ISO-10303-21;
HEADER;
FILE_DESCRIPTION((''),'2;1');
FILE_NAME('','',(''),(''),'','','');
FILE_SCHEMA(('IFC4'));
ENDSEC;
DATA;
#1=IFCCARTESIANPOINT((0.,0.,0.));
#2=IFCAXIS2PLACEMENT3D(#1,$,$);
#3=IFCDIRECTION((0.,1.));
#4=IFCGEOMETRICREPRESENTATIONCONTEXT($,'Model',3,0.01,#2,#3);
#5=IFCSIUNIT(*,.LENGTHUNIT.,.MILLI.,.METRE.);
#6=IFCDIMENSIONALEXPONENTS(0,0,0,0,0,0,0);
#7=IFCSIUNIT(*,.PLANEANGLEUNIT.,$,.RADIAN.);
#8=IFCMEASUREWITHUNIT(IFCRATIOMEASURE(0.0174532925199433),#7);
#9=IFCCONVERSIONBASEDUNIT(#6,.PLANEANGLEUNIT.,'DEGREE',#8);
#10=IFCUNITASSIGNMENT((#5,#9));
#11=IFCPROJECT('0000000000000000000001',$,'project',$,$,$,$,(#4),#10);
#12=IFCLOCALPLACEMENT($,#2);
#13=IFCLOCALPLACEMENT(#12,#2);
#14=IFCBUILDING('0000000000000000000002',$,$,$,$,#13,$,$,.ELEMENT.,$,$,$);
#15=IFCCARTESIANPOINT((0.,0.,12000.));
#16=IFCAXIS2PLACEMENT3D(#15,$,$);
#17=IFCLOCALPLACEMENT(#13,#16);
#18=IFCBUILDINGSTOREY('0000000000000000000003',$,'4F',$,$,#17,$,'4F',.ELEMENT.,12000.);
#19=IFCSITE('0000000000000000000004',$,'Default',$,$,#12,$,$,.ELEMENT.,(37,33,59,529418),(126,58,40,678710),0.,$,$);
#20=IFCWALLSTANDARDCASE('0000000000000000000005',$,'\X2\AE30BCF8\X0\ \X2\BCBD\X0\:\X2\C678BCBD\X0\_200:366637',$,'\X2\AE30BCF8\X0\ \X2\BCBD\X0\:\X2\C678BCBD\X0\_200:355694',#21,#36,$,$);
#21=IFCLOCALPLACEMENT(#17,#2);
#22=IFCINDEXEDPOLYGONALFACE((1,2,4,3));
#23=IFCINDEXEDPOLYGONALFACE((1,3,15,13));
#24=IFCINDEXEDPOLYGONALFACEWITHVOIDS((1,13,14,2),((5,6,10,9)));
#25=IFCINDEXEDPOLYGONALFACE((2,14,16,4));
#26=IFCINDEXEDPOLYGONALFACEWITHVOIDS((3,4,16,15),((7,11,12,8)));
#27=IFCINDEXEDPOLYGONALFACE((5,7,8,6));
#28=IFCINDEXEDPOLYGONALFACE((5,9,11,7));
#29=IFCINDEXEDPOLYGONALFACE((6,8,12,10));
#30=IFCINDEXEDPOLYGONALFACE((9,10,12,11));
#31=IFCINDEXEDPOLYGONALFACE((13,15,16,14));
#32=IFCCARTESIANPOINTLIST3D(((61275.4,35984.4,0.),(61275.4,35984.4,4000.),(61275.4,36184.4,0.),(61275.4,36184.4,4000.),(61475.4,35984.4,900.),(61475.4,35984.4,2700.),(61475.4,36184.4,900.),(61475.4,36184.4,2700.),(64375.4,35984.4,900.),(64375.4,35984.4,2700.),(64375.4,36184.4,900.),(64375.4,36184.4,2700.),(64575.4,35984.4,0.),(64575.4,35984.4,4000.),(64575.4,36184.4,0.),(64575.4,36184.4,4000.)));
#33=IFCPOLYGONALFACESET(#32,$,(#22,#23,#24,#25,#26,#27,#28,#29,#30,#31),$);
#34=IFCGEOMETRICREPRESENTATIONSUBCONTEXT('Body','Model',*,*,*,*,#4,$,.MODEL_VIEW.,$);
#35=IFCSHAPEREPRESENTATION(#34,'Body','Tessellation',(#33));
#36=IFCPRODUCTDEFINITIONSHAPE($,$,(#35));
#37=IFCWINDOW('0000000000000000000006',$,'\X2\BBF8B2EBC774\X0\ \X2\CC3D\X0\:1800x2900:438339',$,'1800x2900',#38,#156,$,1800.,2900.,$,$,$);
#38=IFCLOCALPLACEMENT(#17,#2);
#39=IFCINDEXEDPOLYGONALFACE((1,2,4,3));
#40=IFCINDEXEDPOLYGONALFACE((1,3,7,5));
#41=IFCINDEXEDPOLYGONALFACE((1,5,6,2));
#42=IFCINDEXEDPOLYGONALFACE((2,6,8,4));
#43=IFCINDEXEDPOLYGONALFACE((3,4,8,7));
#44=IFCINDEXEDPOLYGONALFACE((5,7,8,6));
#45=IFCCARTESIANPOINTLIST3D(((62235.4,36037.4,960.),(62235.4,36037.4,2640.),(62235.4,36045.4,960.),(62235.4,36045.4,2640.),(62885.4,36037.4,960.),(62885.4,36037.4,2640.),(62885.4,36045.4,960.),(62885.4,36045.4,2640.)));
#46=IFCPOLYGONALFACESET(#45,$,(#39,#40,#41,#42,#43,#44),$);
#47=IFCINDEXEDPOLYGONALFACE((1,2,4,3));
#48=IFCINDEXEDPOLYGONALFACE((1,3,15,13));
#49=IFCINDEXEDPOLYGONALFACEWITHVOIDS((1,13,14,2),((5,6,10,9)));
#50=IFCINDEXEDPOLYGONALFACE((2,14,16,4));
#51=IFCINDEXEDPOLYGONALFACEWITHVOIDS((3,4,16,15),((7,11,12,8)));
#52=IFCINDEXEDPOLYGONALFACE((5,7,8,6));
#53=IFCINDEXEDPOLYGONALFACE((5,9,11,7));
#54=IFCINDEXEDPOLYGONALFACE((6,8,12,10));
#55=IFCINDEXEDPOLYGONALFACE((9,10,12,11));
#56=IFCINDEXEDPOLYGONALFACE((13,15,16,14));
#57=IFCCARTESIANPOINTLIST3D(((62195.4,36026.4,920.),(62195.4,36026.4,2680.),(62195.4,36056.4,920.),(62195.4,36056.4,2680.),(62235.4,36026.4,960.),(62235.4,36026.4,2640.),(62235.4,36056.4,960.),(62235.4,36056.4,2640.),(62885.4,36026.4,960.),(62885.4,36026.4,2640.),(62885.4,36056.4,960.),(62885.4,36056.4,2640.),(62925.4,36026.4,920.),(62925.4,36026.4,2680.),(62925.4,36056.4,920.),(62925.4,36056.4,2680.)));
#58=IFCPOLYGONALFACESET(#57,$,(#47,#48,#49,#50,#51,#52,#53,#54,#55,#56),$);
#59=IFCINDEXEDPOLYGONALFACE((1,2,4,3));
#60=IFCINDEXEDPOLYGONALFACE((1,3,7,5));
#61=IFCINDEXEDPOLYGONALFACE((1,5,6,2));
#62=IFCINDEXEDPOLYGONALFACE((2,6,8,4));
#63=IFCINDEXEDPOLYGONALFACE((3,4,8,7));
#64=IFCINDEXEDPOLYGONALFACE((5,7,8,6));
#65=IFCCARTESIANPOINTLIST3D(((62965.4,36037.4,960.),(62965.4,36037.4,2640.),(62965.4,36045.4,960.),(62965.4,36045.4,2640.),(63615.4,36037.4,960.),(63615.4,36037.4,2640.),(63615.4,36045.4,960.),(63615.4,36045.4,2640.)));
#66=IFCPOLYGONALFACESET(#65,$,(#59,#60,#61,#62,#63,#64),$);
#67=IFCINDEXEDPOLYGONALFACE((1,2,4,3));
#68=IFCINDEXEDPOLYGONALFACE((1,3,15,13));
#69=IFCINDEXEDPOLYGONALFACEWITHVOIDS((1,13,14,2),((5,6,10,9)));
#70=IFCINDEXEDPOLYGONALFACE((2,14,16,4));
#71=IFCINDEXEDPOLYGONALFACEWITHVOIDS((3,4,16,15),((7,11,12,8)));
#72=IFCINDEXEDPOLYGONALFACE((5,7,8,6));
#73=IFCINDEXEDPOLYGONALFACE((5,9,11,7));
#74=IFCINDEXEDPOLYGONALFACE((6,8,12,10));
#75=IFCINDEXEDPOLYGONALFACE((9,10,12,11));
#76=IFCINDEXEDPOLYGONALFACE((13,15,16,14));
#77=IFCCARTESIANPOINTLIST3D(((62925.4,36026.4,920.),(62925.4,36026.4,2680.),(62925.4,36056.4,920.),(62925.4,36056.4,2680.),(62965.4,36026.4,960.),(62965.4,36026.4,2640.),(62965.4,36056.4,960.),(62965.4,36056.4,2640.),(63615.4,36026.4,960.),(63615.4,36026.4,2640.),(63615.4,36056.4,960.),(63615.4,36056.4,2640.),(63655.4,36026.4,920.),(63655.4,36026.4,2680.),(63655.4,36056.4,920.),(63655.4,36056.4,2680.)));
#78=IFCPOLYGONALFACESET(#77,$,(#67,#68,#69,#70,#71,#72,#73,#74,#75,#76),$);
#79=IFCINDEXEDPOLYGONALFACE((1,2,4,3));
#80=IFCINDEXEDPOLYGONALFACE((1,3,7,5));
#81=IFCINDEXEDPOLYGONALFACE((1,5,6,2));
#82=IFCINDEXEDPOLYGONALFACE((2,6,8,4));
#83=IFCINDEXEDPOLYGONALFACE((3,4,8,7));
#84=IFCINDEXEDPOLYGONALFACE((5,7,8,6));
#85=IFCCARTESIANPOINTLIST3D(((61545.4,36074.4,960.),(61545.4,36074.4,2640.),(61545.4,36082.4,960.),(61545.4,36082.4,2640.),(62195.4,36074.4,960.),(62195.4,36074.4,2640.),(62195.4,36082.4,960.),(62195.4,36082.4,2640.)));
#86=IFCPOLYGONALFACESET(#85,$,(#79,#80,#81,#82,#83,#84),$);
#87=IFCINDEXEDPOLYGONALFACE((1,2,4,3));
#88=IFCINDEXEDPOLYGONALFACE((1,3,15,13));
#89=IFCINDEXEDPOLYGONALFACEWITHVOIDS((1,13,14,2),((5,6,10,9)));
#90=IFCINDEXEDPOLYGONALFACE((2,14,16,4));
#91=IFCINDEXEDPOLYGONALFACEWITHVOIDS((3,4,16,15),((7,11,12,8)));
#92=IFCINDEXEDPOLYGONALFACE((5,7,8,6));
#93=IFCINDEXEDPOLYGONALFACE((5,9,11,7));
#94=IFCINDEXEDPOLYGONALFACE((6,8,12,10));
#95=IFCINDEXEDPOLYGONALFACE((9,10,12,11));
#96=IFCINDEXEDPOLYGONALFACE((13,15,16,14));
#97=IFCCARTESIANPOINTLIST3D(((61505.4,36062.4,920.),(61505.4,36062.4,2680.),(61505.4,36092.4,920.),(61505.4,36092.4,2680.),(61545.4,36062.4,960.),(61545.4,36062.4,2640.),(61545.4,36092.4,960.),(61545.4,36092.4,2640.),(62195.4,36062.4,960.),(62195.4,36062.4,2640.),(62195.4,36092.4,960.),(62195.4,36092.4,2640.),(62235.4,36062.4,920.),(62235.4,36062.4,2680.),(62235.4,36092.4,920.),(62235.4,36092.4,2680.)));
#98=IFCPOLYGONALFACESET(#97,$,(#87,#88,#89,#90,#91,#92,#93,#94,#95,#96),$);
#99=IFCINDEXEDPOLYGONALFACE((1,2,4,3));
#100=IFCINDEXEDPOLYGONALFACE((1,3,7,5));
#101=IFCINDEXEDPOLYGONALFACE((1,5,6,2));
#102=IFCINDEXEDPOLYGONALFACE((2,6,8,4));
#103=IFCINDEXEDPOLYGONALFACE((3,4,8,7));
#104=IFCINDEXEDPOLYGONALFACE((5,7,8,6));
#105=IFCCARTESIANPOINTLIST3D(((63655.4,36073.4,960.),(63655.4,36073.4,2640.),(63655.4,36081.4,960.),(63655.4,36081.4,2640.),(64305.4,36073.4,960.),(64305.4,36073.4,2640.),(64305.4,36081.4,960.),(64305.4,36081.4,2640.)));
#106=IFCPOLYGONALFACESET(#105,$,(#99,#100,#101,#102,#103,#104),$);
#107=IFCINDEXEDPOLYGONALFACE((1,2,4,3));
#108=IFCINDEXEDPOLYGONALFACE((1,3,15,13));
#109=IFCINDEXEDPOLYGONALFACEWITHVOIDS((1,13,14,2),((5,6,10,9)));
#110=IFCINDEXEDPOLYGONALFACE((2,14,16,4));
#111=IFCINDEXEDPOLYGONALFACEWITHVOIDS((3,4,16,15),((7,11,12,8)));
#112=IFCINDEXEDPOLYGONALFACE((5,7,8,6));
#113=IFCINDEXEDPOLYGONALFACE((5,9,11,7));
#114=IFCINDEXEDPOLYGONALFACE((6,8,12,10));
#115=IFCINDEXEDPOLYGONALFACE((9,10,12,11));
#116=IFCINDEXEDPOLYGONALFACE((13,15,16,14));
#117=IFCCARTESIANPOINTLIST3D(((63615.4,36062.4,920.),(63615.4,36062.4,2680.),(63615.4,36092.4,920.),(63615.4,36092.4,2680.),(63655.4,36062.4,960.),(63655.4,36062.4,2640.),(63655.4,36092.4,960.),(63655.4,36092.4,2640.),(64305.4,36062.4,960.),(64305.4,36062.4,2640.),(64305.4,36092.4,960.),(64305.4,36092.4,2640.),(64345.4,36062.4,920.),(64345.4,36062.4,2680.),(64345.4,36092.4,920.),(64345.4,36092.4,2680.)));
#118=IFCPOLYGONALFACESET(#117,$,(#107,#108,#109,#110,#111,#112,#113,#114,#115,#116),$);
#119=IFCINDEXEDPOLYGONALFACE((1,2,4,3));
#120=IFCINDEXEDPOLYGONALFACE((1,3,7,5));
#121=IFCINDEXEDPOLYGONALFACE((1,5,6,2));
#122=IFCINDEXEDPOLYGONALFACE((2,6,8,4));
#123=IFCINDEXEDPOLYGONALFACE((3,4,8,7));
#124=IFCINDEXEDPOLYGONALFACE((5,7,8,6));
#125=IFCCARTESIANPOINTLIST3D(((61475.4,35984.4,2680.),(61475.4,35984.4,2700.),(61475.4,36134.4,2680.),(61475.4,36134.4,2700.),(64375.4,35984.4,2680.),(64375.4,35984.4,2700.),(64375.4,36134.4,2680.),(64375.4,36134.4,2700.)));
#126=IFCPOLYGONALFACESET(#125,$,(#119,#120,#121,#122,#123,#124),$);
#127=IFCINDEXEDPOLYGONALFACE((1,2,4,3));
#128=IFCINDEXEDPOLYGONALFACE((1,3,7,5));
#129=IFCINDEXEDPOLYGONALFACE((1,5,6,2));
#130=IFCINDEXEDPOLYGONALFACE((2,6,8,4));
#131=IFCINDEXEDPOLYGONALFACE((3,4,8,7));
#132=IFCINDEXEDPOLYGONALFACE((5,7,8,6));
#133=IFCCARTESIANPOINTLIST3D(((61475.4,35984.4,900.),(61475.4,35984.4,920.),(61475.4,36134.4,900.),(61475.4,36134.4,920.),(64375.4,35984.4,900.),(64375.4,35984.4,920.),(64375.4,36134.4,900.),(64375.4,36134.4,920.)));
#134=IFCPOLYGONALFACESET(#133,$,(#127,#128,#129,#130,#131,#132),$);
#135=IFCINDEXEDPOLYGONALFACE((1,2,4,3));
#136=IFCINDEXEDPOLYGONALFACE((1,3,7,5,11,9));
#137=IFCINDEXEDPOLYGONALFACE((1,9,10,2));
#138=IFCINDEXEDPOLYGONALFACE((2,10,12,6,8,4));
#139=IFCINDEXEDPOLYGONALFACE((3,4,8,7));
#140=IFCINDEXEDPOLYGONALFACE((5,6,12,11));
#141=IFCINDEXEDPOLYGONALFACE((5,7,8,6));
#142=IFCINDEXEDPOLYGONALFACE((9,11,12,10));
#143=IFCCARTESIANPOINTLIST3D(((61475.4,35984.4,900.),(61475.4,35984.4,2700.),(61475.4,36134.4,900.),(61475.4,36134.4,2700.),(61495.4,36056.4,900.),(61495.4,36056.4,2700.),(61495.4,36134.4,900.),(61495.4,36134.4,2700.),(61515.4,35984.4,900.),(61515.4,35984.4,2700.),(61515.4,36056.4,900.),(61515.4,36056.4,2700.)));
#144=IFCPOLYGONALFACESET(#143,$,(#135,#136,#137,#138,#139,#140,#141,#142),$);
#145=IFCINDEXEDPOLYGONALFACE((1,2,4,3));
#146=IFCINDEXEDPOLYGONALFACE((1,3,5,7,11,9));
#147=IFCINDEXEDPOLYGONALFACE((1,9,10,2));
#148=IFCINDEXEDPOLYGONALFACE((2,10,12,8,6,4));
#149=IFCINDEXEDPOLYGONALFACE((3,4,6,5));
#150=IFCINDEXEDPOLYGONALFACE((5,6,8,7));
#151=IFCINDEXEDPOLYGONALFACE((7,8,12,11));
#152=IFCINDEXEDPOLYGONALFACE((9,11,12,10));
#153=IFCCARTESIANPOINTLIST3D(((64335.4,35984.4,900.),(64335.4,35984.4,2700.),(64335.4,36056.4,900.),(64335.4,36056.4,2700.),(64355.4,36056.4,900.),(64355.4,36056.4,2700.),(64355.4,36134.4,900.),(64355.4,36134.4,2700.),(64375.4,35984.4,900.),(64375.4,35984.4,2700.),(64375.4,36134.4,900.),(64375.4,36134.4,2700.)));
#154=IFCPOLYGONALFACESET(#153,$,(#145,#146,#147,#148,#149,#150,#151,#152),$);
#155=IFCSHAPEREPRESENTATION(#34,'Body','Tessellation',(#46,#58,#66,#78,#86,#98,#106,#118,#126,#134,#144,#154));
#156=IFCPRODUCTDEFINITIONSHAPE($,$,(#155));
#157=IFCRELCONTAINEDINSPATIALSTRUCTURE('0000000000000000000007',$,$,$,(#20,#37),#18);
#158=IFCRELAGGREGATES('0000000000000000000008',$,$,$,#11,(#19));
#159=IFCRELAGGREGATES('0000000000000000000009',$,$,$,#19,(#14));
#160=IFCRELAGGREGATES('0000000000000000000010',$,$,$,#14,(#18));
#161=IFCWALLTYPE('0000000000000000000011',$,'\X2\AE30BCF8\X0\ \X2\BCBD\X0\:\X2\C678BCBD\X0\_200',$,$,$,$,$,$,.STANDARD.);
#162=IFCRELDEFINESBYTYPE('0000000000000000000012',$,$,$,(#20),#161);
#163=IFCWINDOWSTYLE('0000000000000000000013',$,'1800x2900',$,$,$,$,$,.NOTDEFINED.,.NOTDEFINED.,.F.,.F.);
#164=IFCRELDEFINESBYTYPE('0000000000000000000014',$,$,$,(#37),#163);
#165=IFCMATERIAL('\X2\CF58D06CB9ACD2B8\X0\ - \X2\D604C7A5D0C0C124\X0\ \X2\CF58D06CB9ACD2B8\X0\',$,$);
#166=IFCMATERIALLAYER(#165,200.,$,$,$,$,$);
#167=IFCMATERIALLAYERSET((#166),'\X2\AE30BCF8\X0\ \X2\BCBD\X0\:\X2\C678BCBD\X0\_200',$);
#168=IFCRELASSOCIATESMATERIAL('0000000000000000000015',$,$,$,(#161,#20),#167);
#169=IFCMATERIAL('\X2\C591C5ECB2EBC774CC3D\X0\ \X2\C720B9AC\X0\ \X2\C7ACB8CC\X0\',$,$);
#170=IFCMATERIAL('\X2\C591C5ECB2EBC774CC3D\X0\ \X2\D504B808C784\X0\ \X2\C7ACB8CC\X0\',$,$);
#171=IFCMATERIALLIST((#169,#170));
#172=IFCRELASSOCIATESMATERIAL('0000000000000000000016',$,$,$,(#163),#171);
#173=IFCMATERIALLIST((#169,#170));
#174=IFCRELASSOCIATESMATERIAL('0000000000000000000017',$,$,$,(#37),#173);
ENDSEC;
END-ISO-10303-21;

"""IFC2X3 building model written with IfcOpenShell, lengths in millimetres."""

from ifc_helpers import new_model, entity, si_unit, converted_unit, direction, frame, frame_2d, origin, origin_2d_with_axis, place, context, subcontext, project, spatial, polyline, rectangle, outline, extrude, source, transform, mapped, material, material_list, layer, layer_set, layer_usage, type_object, type_shapes, element, fill, save


model = new_model("IFC2X3")

# Units and contexts
model_context = context("Model", 3, precision=0.01, world=origin(), true_north=direction((0.0, 1.0)))
body_context = subcontext(model_context, "Body", "Model", "MODEL_VIEW")
ifc_project = project(units=[si_unit("LENGTHUNIT", "METRE", prefix="MILLI"), converted_unit("PLANEANGLEUNIT", "DEGREE", entity("IfcRatioMeasure", 0.0174532925199433), si_unit("PLANEANGLEUNIT", "RADIAN"), dimensions=[0, 0, 0, 0, 0, 0, 0])], contexts=[model_context])

# Site, building, storey
site_placement = place(None, origin())
site = spatial("IfcSite", under=ifc_project, at=site_placement, Name="Default", CompositionType="ELEMENT", RefLatitude=(37, 33, 59, 529418), RefLongitude=(126, 58, 40, 678710), RefElevation=0.0)
building_placement = place(site_placement, origin())
building = spatial("IfcBuilding", under=site, at=building_placement, CompositionType="ELEMENT")
storey_placement = place(building_placement, frame((0.0, 0.0, 12000.0)))
storey = spatial("IfcBuildingStorey", under=building, at=storey_placement, Name="4F", LongName="4F", CompositionType="ELEMENT", Elevation=12000.0)

# Wall, opening, window
ifc_material_1 = material(Name="콘크리트 - 현장타설 콘크리트")
ifc_layer_1 = layer(ifc_material_1, 200.0)
ifc_layer_set_1 = layer_set([ifc_layer_1], Name="기본 벽:외벽_200")
wall_type_1 = type_object("IfcWallType", Name="기본 벽:외벽_200", PredefinedType="STANDARD", material=ifc_layer_set_1)
ifc_material_2 = material(Name="양여닫이창 유리 재료")
ifc_material_3 = material(Name="양여닫이창 프레임 재료")
ifc_material_list_1 = material_list([ifc_material_2, ifc_material_3])
window_style = type_object("IfcWindowStyle", Name="1800x2900", ConstructionType="NOTDEFINED", OperationType="NOTDEFINED", ParameterTakesPrecedence=False, Sizeable=False, material=ifc_material_list_1)
shared_shape_1 = source(origin(), body_context, "Body", "SweptSolid", [
    extrude(rectangle(XDim=8.0, YDim=650.0, at=frame_2d((0.0, 0.0), x_axis=(1.0, 0.0))), frame((1815.0, 143.0, 60.0), z_axis=(0.0, 0.0, 1.0), x_axis=(0.0, 1.0, 0.0)), (0.0, 0.0, 1.0), 1680.0),
    extrude(outline(polyline([(-880.0, -365.0), (880.0, -365.0), (880.0, 365.0), (-880.0, 365.0), (-880.0, -365.0)]), holes=[polyline([(840.0, -325.0), (-840.0, -325.0), (-840.0, 325.0), (840.0, 325.0), (840.0, -325.0)])]), frame((1815.0, 128.0, 900.0), z_axis=(0.0, 1.0, 0.0), x_axis=(0.0, 0.0, -1.0)), (0.0, 0.0, 1.0), 30.0),
    extrude(rectangle(XDim=8.0, YDim=650.0, at=frame_2d((0.0, 0.0), x_axis=(1.0, 0.0))), frame((1085.0, 143.0, 60.0), z_axis=(0.0, 0.0, 1.0), x_axis=(0.0, 1.0, 0.0)), (0.0, 0.0, 1.0), 1680.0),
    extrude(outline(polyline([(-880.0, -365.0), (880.0, -365.0), (880.0, 365.0), (-880.0, 365.0), (-880.0, -365.0)]), holes=[polyline([(840.0, -325.0), (-840.0, -325.0), (-840.0, 325.0), (840.0, 325.0), (840.0, -325.0)])]), frame((1085.0, 128.0, 900.0), z_axis=(0.0, 1.0, 0.0), x_axis=(0.0, 0.0, -1.0)), (0.0, 0.0, 1.0), 30.0),
    extrude(rectangle(XDim=8.0, YDim=650.0, at=frame_2d((0.0, 0.0), x_axis=(1.0, 0.0))), frame((2505.0, 106.0, 60.0), z_axis=(0.0, 0.0, 1.0), x_axis=(0.0, 1.0, 0.0)), (0.0, 0.0, 1.0), 1680.0),
    extrude(outline(polyline([(-880.0, -365.0), (880.0, -365.0), (880.0, 365.0), (-880.0, 365.0), (-880.0, -365.0)]), holes=[polyline([(840.0, -325.0), (-840.0, -325.0), (-840.0, 325.0), (840.0, 325.0), (840.0, -325.0)])]), frame((2505.0, 92.0, 900.0), z_axis=(0.0, 1.0, 0.0), x_axis=(0.0, 0.0, -1.0)), (0.0, 0.0, 1.0), 30.0),
    extrude(rectangle(XDim=8.0, YDim=650.0, at=origin_2d_with_axis()), frame((395.0, 107.0, 60.0), z_axis=(0.0, 0.0, 1.0), x_axis=(0.0, 1.0, 0.0)), (0.0, 0.0, 1.0), 1680.0),
    extrude(outline(polyline([(-880.0, -365.0), (880.0, -365.0), (880.0, 365.0), (-880.0, 365.0), (-880.0, -365.0)]), holes=[polyline([(840.0, -325.0), (-840.0, -325.0), (-840.0, 325.0), (840.0, 325.0), (840.0, -325.0)])]), frame((395.0, 92.0, 900.0), z_axis=(0.0, 1.0, 0.0), x_axis=(0.0, 0.0, -1.0)), (0.0, 0.0, 1.0), 30.0),
    extrude(rectangle(XDim=2900.0, YDim=150.0, at=origin_2d_with_axis()), frame((1450.0, 125.0, 1780.0), z_axis=(0.0, 0.0, 1.0), x_axis=(-1.0, 0.0, 0.0)), (0.0, 0.0, 1.0), 20.0),
    extrude(rectangle(XDim=2900.0, YDim=150.0, at=origin_2d_with_axis()), frame((1450.0, 125.0, 0.0), z_axis=(0.0, 0.0, 1.0), x_axis=(-1.0, 0.0, 0.0)), (0.0, 0.0, 1.0), 20.0),
    extrude(outline(polyline([(-74.0, -20.0), (-2.0, -20.0), (-2.0, 0.0), (76.0, 0.0), (76.0, 20.0), (-74.0, 20.0), (-74.0, -20.0)])), frame((2880.0, 126.0, 0.0), z_axis=(0.0, 0.0, 1.0), x_axis=(0.0, -1.0, 0.0)), (0.0, 0.0, 1.0), 1800.0),
    extrude(outline(polyline([(-20.0, -74.0), (20.0, -74.0), (20.0, 76.0), (0.0, 76.0), (0.0, -2.0), (-20.0, -2.0), (-20.0, -74.0)])), frame((20.0, 126.0, 0.0), z_axis=(0.0, 0.0, 1.0), x_axis=(-1.0, 0.0, 0.0)), (0.0, 0.0, 1.0), 1800.0),
])
type_shapes(window_style, [shared_shape_1])
ifc_layer_usage_1 = layer_usage(ifc_layer_set_1, "AXIS2", "NEGATIVE", 100.0)
wall_1_placement = place(storey_placement, frame((64575.4, 36084.4, 0.0), z_axis=(0.0, 0.0, 1.0), x_axis=(-1.0, 0.0, 0.0)))
wall_1 = element("IfcWallStandardCase", 1, at=wall_1_placement, inside=storey, type_object=wall_type_1, material=ifc_layer_usage_1, Name="기본 벽:외벽_200:366637", ObjectType="기본 벽:외벽_200:355694", context=body_context, shape_type="SweptSolid", body=[
    extrude(rectangle(XDim=3300.0, YDim=200.0, at=frame_2d((1650.0, 0.0), x_axis=(-1.0, 0.0))), origin(), (0.0, 0.0, 1.0), 4000.0),
])
opening_1_placement = place(wall_1_placement, frame((200.0, -100.0, 900.0)))
opening_1 = element("IfcOpeningElement", 2, at=opening_1_placement, cuts=wall_1, ObjectType="Opening", context=body_context, shape_type="SweptSolid", body=[
    extrude(rectangle(XDim=1800.0, YDim=2900.0, at=frame_2d((900.0, 1450.0), x_axis=(1.0, 0.0))), frame((0.0, 0.0, 0.0), z_axis=(0.0, 1.0, 0.0), x_axis=(0.0, 0.0, 1.0)), (0.0, 0.0, 1.0), 200.0),
])
ifc_material_list_2 = material_list([ifc_material_2, ifc_material_3])
window_1_placement = place(opening_1_placement, origin())
window_1 = element("IfcWindow", 3, at=window_1_placement, inside=storey, type_object=window_style, material=ifc_material_list_2, Name="미닫이 창:1800x2900:438339", ObjectType="1800x2900", OverallHeight=1800.0, OverallWidth=2900.0, context=body_context, shape_type="MappedRepresentation", body=[
    mapped(shared_shape_1, transform((0.0, 0.0, 0.0), scale=1.0)),
])
fill(opening_1, window_1)

save(model, "model.ifc")
